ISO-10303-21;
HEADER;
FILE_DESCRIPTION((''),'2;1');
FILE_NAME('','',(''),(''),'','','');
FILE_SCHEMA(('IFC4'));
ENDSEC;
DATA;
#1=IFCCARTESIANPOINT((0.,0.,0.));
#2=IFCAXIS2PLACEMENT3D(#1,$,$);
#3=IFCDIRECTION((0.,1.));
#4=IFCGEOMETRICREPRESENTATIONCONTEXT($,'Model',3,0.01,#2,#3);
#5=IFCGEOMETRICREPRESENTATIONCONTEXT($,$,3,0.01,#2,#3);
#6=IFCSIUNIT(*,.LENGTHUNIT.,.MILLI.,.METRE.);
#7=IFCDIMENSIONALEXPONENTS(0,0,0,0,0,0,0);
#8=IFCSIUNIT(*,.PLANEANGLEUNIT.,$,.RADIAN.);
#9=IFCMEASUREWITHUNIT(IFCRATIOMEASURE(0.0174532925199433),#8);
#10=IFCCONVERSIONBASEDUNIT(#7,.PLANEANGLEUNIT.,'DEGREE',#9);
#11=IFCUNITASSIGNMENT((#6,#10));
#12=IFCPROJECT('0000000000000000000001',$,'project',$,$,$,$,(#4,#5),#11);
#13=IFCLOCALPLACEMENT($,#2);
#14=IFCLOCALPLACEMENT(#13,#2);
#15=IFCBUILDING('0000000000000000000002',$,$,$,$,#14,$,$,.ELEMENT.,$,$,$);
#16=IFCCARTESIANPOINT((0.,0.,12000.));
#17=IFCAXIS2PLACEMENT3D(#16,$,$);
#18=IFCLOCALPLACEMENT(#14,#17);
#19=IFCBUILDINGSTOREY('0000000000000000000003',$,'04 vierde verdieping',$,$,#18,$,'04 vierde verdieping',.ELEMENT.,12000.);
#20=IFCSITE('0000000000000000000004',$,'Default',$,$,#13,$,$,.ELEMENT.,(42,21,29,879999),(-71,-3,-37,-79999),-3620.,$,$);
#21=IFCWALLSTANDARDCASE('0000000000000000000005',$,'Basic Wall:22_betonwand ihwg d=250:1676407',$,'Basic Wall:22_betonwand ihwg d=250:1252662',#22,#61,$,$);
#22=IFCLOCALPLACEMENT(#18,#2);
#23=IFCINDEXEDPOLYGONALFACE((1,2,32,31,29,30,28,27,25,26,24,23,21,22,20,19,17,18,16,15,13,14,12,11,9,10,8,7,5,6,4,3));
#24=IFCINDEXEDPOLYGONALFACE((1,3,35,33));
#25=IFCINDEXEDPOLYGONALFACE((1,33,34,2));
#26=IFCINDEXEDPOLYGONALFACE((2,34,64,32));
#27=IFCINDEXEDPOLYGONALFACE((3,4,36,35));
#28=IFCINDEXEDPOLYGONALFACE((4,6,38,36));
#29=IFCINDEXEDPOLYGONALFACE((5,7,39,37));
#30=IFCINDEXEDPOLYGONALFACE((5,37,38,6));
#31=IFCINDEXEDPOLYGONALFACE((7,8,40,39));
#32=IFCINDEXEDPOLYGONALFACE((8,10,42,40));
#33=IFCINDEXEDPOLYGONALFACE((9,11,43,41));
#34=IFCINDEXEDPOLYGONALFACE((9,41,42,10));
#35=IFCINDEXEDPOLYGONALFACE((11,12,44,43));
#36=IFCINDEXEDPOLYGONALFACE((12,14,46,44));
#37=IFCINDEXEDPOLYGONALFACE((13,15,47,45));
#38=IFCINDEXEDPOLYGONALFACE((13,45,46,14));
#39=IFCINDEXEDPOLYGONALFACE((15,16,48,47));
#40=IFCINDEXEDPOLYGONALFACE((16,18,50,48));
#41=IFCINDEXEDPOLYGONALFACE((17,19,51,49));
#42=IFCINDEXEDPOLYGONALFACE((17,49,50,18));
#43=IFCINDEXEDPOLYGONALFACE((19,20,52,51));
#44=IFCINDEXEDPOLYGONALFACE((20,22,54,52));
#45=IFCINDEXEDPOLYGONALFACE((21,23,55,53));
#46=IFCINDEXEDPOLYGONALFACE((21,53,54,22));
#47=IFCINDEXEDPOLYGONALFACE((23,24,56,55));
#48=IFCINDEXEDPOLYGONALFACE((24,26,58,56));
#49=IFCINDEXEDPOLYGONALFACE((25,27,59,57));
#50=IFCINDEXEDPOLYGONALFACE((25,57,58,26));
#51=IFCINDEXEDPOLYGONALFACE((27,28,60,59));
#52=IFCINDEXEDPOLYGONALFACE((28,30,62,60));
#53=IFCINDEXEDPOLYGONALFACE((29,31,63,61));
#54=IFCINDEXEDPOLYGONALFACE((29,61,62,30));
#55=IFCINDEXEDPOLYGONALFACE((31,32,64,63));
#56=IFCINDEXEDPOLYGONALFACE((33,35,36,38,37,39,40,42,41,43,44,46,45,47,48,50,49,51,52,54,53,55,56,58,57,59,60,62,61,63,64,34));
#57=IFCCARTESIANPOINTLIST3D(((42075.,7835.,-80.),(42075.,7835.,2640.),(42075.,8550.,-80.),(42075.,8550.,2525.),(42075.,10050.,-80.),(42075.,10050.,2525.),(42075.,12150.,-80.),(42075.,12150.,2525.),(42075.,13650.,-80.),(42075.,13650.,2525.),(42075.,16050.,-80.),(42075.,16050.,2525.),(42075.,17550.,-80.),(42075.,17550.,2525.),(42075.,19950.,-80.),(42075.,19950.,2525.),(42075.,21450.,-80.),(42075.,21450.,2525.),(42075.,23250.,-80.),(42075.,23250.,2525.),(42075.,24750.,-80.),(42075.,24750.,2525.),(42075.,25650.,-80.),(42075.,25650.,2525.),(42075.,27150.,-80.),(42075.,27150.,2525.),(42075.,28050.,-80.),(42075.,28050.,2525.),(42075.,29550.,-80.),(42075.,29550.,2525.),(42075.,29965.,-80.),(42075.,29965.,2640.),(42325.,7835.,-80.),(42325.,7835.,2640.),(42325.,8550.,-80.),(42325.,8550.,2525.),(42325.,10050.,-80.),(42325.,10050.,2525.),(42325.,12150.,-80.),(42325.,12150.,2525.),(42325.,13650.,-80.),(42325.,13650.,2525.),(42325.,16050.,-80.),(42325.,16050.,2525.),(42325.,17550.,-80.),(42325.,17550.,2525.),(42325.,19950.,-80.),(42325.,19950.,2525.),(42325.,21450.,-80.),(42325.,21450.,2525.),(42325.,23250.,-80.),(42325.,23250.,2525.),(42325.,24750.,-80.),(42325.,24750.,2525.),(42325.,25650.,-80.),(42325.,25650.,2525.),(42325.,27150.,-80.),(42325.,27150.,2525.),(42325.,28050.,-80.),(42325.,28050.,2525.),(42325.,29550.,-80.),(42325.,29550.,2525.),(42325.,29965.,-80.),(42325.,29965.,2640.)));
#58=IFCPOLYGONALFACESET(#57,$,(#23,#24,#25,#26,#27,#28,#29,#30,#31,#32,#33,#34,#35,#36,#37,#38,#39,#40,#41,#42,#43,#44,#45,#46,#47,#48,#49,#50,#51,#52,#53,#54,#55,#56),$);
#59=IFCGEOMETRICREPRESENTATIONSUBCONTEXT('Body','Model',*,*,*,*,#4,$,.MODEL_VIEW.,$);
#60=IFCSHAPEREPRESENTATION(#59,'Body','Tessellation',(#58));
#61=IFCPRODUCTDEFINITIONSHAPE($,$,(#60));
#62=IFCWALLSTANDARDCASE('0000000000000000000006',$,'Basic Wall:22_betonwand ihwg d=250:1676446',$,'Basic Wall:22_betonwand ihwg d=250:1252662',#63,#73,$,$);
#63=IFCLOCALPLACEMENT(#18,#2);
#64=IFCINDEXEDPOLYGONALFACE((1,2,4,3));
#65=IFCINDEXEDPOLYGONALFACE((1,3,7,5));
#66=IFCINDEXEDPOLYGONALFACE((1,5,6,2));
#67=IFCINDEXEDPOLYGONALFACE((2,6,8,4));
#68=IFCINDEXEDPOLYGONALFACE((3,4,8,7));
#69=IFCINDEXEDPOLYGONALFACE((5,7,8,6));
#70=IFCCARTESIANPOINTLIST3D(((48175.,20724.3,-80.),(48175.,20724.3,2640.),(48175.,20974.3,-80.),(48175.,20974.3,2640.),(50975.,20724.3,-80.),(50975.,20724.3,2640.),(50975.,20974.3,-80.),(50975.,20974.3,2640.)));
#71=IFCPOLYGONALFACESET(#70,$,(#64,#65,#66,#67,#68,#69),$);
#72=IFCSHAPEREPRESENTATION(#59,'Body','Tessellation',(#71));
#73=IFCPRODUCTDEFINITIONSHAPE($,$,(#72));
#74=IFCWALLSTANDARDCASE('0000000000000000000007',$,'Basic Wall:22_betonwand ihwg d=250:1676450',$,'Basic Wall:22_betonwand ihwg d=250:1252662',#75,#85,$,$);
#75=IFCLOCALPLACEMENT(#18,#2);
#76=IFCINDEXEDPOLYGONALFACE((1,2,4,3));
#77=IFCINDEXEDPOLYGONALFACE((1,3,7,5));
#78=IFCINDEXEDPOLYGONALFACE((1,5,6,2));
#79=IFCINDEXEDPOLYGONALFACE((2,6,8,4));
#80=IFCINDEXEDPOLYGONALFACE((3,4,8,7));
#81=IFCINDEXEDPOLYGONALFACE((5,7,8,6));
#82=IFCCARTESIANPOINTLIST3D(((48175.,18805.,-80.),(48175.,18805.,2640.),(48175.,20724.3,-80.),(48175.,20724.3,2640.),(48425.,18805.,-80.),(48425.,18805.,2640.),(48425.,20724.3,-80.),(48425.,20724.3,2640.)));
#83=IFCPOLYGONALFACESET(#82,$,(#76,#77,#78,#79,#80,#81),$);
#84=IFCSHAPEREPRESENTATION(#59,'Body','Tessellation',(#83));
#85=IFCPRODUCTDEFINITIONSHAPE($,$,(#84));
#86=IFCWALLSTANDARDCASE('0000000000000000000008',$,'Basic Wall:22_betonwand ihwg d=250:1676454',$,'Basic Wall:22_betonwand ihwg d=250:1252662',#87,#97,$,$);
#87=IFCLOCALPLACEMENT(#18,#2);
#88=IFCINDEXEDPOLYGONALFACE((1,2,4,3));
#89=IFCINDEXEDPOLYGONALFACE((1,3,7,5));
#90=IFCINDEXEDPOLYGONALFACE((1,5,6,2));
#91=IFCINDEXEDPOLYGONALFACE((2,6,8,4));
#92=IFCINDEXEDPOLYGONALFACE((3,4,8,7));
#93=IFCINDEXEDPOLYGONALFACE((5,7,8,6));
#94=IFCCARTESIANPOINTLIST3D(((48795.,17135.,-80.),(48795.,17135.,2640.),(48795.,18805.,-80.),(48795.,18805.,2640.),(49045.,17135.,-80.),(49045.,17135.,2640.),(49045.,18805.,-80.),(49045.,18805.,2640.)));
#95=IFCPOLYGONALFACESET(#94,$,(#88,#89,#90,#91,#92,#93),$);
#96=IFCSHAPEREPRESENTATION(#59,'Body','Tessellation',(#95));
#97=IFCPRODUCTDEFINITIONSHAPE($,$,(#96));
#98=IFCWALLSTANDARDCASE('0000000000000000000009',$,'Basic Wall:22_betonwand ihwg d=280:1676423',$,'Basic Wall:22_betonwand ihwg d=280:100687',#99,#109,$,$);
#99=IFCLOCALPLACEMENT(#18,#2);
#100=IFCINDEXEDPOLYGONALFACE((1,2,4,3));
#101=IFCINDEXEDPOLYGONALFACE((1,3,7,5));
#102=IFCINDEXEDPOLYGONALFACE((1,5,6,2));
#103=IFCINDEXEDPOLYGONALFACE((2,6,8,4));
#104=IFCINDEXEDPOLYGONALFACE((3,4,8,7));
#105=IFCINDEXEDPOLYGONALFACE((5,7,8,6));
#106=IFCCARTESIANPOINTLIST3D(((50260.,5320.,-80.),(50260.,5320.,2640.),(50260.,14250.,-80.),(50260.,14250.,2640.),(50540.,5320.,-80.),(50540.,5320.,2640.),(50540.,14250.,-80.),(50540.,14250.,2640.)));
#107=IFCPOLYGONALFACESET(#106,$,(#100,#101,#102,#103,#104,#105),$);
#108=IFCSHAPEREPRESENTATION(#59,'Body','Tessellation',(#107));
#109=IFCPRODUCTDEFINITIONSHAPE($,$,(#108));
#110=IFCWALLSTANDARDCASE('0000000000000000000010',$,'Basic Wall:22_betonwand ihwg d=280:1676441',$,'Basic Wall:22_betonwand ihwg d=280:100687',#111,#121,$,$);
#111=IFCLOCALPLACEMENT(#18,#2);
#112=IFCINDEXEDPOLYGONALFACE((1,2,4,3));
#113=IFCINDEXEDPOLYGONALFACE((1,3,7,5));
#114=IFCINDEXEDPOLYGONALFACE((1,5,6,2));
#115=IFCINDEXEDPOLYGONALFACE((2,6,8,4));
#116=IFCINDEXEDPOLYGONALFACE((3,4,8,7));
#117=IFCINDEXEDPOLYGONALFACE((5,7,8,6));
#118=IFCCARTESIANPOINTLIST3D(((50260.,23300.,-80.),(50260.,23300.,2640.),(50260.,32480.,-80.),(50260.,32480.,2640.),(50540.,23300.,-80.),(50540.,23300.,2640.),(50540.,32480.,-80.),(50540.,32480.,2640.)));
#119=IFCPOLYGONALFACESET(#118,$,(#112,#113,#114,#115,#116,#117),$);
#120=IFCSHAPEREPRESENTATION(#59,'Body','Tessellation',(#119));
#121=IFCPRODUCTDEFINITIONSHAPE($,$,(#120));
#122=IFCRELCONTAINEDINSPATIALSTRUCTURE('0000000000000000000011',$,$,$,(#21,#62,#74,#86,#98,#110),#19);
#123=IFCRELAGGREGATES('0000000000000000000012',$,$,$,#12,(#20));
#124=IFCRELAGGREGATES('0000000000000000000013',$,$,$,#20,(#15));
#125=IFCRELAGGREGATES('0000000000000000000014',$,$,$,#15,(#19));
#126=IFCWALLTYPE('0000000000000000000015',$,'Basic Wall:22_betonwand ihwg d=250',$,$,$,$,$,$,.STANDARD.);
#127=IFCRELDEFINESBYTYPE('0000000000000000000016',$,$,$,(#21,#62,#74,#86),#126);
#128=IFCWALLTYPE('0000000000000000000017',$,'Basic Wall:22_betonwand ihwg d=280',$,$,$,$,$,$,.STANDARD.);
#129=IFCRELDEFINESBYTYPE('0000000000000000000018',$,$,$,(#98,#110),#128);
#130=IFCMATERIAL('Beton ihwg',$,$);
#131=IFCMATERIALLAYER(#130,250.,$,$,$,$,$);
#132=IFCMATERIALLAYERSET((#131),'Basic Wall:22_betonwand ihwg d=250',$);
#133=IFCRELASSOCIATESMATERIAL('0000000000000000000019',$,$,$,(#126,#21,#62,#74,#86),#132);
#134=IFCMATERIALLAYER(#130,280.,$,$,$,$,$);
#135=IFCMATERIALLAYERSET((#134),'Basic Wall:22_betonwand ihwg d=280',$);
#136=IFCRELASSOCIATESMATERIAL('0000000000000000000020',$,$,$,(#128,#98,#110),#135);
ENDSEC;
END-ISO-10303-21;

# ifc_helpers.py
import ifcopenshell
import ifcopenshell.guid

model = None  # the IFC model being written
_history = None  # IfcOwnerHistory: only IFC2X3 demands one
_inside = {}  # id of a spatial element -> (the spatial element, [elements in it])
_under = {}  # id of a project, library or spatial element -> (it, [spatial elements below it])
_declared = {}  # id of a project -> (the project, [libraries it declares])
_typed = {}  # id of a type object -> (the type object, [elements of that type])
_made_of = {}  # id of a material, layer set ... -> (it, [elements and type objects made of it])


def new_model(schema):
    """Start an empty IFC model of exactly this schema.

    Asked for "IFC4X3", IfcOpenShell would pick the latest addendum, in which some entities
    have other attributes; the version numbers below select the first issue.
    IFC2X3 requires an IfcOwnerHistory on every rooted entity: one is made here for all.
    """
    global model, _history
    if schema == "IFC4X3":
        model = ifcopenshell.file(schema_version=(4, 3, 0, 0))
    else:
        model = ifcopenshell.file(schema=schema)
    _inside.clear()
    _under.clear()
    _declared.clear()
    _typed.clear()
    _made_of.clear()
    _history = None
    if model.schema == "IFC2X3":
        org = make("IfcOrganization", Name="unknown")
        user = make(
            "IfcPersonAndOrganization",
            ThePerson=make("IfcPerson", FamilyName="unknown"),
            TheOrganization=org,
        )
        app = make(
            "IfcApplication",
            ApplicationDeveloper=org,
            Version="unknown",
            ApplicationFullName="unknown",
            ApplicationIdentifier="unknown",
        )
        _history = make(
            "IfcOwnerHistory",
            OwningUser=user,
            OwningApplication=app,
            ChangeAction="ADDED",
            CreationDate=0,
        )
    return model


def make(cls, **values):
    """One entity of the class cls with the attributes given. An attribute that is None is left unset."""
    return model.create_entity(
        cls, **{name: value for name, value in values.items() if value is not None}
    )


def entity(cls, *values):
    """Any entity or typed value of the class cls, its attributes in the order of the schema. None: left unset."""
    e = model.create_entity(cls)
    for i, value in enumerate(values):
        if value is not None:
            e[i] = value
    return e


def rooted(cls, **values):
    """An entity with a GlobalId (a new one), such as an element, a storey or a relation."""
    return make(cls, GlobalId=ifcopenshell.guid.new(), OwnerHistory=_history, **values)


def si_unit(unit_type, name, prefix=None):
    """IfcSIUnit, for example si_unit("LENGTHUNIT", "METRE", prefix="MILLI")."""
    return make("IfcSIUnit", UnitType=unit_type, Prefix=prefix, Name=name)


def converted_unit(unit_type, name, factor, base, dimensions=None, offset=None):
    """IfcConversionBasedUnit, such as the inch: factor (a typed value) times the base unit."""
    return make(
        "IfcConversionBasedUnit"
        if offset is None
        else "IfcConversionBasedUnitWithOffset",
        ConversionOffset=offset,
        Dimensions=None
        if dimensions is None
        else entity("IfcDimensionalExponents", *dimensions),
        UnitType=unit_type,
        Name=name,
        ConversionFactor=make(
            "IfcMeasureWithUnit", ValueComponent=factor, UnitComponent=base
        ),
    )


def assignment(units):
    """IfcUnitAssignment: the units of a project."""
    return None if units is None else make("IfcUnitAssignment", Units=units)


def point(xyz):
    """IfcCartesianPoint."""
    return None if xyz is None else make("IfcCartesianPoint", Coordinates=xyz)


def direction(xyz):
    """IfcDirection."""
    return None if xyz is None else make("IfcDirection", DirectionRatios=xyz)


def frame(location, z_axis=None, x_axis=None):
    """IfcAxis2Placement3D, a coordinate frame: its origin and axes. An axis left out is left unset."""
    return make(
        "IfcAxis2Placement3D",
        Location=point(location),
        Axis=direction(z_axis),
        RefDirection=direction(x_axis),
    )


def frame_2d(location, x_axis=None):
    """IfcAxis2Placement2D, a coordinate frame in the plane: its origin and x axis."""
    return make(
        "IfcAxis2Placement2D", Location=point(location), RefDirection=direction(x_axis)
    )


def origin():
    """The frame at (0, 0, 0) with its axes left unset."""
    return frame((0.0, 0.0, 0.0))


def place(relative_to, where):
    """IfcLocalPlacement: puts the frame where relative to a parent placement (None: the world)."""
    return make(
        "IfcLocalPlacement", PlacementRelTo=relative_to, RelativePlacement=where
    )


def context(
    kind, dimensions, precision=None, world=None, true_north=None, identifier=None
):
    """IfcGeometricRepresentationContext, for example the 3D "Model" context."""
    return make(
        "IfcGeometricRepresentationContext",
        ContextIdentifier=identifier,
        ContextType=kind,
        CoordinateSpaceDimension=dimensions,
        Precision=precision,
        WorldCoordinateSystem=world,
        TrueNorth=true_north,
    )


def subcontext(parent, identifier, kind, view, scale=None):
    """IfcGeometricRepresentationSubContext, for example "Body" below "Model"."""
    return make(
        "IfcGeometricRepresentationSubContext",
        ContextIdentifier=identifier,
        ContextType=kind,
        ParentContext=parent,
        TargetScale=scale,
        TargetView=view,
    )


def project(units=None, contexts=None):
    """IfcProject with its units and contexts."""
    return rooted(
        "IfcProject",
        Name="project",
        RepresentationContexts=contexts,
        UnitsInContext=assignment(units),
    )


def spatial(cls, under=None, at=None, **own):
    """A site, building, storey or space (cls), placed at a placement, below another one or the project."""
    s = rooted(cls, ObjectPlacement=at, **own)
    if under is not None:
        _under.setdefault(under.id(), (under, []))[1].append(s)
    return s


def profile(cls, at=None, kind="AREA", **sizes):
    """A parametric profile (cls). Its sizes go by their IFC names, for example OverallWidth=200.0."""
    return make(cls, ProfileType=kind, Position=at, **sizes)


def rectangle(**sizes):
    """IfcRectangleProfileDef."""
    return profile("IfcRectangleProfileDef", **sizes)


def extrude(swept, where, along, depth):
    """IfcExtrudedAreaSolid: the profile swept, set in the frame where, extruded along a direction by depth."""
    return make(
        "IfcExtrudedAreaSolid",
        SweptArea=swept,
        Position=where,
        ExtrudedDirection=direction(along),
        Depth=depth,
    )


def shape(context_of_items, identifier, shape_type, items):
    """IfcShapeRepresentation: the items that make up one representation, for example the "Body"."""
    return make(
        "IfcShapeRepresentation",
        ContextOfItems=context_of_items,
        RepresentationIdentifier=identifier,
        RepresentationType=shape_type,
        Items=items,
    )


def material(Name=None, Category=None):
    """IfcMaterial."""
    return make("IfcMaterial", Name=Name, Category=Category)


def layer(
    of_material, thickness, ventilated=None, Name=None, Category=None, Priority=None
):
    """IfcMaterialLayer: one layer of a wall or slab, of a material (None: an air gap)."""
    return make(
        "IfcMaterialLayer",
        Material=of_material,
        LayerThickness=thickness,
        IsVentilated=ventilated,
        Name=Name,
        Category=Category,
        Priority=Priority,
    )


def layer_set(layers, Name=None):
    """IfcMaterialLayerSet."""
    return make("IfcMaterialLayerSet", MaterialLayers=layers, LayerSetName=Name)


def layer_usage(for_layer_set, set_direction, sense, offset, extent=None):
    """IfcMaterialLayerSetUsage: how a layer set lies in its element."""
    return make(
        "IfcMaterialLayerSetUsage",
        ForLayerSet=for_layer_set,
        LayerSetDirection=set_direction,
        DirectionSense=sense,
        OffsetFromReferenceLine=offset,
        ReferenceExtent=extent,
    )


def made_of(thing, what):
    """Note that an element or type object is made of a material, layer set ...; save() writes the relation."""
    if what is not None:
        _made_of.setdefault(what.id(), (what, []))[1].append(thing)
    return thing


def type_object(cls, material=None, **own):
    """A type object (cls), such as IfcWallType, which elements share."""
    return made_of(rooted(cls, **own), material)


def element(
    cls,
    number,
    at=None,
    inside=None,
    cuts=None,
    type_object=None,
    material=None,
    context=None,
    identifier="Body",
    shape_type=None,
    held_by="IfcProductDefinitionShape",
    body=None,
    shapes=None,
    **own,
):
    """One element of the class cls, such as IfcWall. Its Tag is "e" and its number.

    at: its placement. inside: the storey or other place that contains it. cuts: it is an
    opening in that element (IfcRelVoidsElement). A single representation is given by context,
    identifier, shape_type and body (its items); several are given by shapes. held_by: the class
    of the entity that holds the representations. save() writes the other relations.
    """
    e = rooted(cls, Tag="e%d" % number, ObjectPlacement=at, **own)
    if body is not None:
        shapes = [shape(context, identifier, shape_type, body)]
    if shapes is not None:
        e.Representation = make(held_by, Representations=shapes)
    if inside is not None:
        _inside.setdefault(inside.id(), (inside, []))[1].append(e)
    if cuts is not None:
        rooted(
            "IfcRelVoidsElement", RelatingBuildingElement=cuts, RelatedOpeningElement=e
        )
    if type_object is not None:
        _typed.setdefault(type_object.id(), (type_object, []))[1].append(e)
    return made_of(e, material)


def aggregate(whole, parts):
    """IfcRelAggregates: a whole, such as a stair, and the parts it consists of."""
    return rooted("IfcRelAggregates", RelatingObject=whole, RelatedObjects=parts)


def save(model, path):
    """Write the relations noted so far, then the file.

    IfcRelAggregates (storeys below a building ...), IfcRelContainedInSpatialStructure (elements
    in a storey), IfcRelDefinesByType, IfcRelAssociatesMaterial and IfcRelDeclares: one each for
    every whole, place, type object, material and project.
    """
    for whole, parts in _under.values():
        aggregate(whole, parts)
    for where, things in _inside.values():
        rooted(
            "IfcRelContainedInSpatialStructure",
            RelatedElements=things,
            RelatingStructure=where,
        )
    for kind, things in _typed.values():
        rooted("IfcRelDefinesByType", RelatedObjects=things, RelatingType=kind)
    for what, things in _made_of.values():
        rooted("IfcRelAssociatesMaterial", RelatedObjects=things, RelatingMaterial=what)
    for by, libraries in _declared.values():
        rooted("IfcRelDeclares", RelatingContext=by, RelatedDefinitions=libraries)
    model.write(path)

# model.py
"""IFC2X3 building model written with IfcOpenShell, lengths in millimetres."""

from ifc_helpers import new_model, entity, si_unit, converted_unit, direction, frame, frame_2d, origin, place, context, subcontext, project, spatial, rectangle, extrude, material, layer, layer_set, layer_usage, type_object, element, save


model = new_model("IFC2X3")

# Units and contexts
model_context = context("Model", 3, precision=0.01, world=origin(), true_north=direction((0.0, 1.0)))
context_of_model = context(None, 3, precision=0.01, world=origin(), true_north=direction((0.0, 1.0)))
body_context = subcontext(model_context, "Body", "Model", "MODEL_VIEW")
ifc_project = project(units=[si_unit("LENGTHUNIT", "METRE", prefix="MILLI"), converted_unit("PLANEANGLEUNIT", "DEGREE", entity("IfcRatioMeasure", 0.0174532925199433), si_unit("PLANEANGLEUNIT", "RADIAN"), dimensions=[0, 0, 0, 0, 0, 0, 0])], contexts=[model_context, context_of_model])

# Site, building, storey
site_placement = place(None, origin())
site = spatial("IfcSite", under=ifc_project, at=site_placement, Name="Default", CompositionType="ELEMENT", RefLatitude=(42, 21, 29, 879999), RefLongitude=(-71, -3, -37, -79999), RefElevation=-3620.0)
building_placement = place(site_placement, origin())
building = spatial("IfcBuilding", under=site, at=building_placement, CompositionType="ELEMENT")
storey_placement = place(building_placement, frame((0.0, 0.0, 12000.0)))
storey = spatial("IfcBuildingStorey", under=building, at=storey_placement, Name="04 vierde verdieping", LongName="04 vierde verdieping", CompositionType="ELEMENT", Elevation=12000.0)

# Shared definitions
ifc_material_1 = material(Name="Beton ihwg")

# Wall, openings
ifc_layer_1 = layer(ifc_material_1, 250.0)
ifc_layer_set_1 = layer_set([ifc_layer_1], Name="Basic Wall:22_betonwand ihwg d=250")
ifc_layer_usage_1 = layer_usage(ifc_layer_set_1, "AXIS2", "POSITIVE", -125.0)
wall_type_1 = type_object("IfcWallType", Name="Basic Wall:22_betonwand ihwg d=250", PredefinedType="STANDARD", material=ifc_layer_set_1)
wall_1_placement = place(storey_placement, frame((42200.0, 29965.0, -80.0), z_axis=(0.0, 0.0, 1.0), x_axis=(0.0, -1.0, 0.0)))
wall_1 = element("IfcWallStandardCase", 1, at=wall_1_placement, inside=storey, type_object=wall_type_1, material=ifc_layer_usage_1, Name="Basic Wall:22_betonwand ihwg d=250:1676407", ObjectType="Basic Wall:22_betonwand ihwg d=250:1252662", context=body_context, shape_type="SweptSolid", body=[
    extrude(rectangle(XDim=22130.0, YDim=250.0, at=frame_2d((11065.0, 0.0), x_axis=(-1.0, 0.0))), origin(), (0.0, 0.0, 1.0), 2720.0),
])
opening_1_placement = place(wall_1_placement, frame((29965.0, -42200.0, 80.0), z_axis=(0.0, 0.0, 1.0), x_axis=(0.0, 1.0, 0.0)))
element("IfcOpeningElement", 2, at=opening_1_placement, cuts=wall_1, ObjectType="Opening", context=body_context, shape_type="SweptSolid", body=[
    extrude(rectangle(XDim=2605.0, YDim=1500.0, at=frame_2d((0.0, 0.0), x_axis=(1.0, 0.0))), frame((40801.0, 28800.0, 1222.5), z_axis=(1.0, 0.0, 0.0), x_axis=(0.0, 0.0, -1.0)), (0.0, 0.0, 1.0), 3048.0),
])
opening_2_placement = place(wall_1_placement, frame((29965.0, -42200.0, 80.0), z_axis=(0.0, 0.0, 1.0), x_axis=(0.0, 1.0, 0.0)))
element("IfcOpeningElement", 3, at=opening_2_placement, cuts=wall_1, ObjectType="Opening", context=body_context, shape_type="SweptSolid", body=[
    extrude(rectangle(XDim=2605.0, YDim=1500.0, at=frame_2d((0.0, 0.0), x_axis=(1.0, 0.0))), frame((40801.0, 26400.0, 1222.5), z_axis=(1.0, 0.0, 0.0), x_axis=(0.0, 0.0, -1.0)), (0.0, 0.0, 1.0), 3048.0),
])
opening_3_placement = place(wall_1_placement, frame((29965.0, -42200.0, 80.0), z_axis=(0.0, 0.0, 1.0), x_axis=(0.0, 1.0, 0.0)))
element("IfcOpeningElement", 4, at=opening_3_placement, cuts=wall_1, ObjectType="Opening", context=body_context, shape_type="SweptSolid", body=[
    extrude(rectangle(XDim=2605.0, YDim=1500.0, at=frame_2d((0.0, 0.0), x_axis=(1.0, 0.0))), frame((40801.0, 24000.0, 1222.5), z_axis=(1.0, 0.0, 0.0), x_axis=(0.0, 0.0, -1.0)), (0.0, 0.0, 1.0), 3048.0),
])
opening_4_placement = place(wall_1_placement, frame((29965.0, -42200.0, 80.0), z_axis=(0.0, 0.0, 1.0), x_axis=(0.0, 1.0, 0.0)))
element("IfcOpeningElement", 5, at=opening_4_placement, cuts=wall_1, ObjectType="Opening", context=body_context, shape_type="SweptSolid", body=[
    extrude(rectangle(XDim=2605.0, YDim=1500.0, at=frame_2d((0.0, 0.0), x_axis=(1.0, 0.0))), frame((40801.0, 16800.0, 1222.5), z_axis=(1.0, 0.0, 0.0), x_axis=(0.0, 0.0, -1.0)), (0.0, 0.0, 1.0), 3048.0),
])
opening_5_placement = place(wall_1_placement, frame((29965.0, -42200.0, -2920.0), z_axis=(0.0, 0.0, 1.0), x_axis=(0.0, 1.0, 0.0)))
element("IfcOpeningElement", 6, at=opening_5_placement, cuts=wall_1, ObjectType="Opening", context=body_context, shape_type="SweptSolid", body=[
    extrude(rectangle(XDim=2605.0, YDim=1500.0, at=frame_2d((0.0, 0.0), x_axis=(1.0, 0.0))), frame((40801.0, 9300.0, 4222.5), z_axis=(1.0, 0.0, 0.0), x_axis=(0.0, 0.0, -1.0)), (0.0, 0.0, 1.0), 3048.0),
])
opening_6_placement = place(wall_1_placement, frame((29965.0, -42200.0, 80.0), z_axis=(0.0, 0.0, 1.0), x_axis=(0.0, 1.0, 0.0)))
element("IfcOpeningElement", 7, at=opening_6_placement, cuts=wall_1, ObjectType="Opening", context=body_context, shape_type="SweptSolid", body=[
    extrude(rectangle(XDim=2605.0, YDim=1500.0, at=frame_2d((0.0, 0.0), x_axis=(0.0, 1.0))), frame((40551.0, 12900.0, 1222.5), z_axis=(1.0, 0.0, 0.0), x_axis=(0.0, -1.0, 0.0)), (0.0, 0.0, 1.0), 3048.0),
])
opening_7_placement = place(wall_1_placement, frame((29965.0, -42200.0, 80.0), z_axis=(0.0, 0.0, 1.0), x_axis=(0.0, 1.0, 0.0)))
element("IfcOpeningElement", 8, at=opening_7_placement, cuts=wall_1, ObjectType="Opening", context=body_context, shape_type="SweptSolid", body=[
    extrude(rectangle(XDim=2605.0, YDim=1500.0, at=frame_2d((0.0, 0.0), x_axis=(1.0, 0.0))), frame((40801.0, 20700.0, 1222.5), z_axis=(1.0, 0.0, 0.0), x_axis=(0.0, 0.0, -1.0)), (0.0, 0.0, 1.0), 3048.0),
])

# Walls
ifc_layer_usage_2 = layer_usage(ifc_layer_set_1, "AXIS2", "POSITIVE", -125.0)
wall_2_placement = place(storey_placement, frame((50975.0, 20849.3, -80.0), z_axis=(0.0, 0.0, 1.0), x_axis=(-1.0, 0.0, 0.0)))
element("IfcWallStandardCase", 9, at=wall_2_placement, inside=storey, type_object=wall_type_1, material=ifc_layer_usage_2, Name="Basic Wall:22_betonwand ihwg d=250:1676446", ObjectType="Basic Wall:22_betonwand ihwg d=250:1252662", context=body_context, shape_type="SweptSolid", body=[
    extrude(rectangle(XDim=2800.0, YDim=250.0, at=frame_2d((1400.0, 0.0), x_axis=(-1.0, 0.0))), origin(), (0.0, 0.0, 1.0), 2720.0),
])
ifc_layer_usage_3 = layer_usage(ifc_layer_set_1, "AXIS2", "POSITIVE", -125.0)
wall_3_placement = place(storey_placement, frame((48300.0, 20724.3, -80.0), z_axis=(0.0, 0.0, 1.0), x_axis=(0.0, -1.0, 0.0)))
element("IfcWallStandardCase", 10, at=wall_3_placement, inside=storey, type_object=wall_type_1, material=ifc_layer_usage_3, Name="Basic Wall:22_betonwand ihwg d=250:1676450", ObjectType="Basic Wall:22_betonwand ihwg d=250:1252662", context=body_context, shape_type="SweptSolid", body=[
    extrude(rectangle(XDim=1919.3, YDim=250.0, at=frame_2d((959.6, 0.0), x_axis=(-1.0, 0.0))), origin(), (0.0, 0.0, 1.0), 2720.0),
])
ifc_layer_usage_4 = layer_usage(ifc_layer_set_1, "AXIS2", "POSITIVE", -125.0)
wall_4_placement = place(storey_placement, frame((48920.0, 18805.0, -80.0), z_axis=(0.0, 0.0, 1.0), x_axis=(0.0, -1.0, 0.0)))
element("IfcWallStandardCase", 11, at=wall_4_placement, inside=storey, type_object=wall_type_1, material=ifc_layer_usage_4, Name="Basic Wall:22_betonwand ihwg d=250:1676454", ObjectType="Basic Wall:22_betonwand ihwg d=250:1252662", context=body_context, shape_type="SweptSolid", body=[
    extrude(rectangle(XDim=1670.0, YDim=250.0, at=frame_2d((835.0, 0.0), x_axis=(-1.0, 0.0))), origin(), (0.0, 0.0, 1.0), 2720.0),
])
ifc_layer_2 = layer(ifc_material_1, 280.0)
ifc_layer_set_2 = layer_set([ifc_layer_2], Name="Basic Wall:22_betonwand ihwg d=280")
ifc_layer_usage_5 = layer_usage(ifc_layer_set_2, "AXIS2", "NEGATIVE", 140.0)
wall_type_2 = type_object("IfcWallType", Name="Basic Wall:22_betonwand ihwg d=280", PredefinedType="STANDARD", material=ifc_layer_set_2)
wall_5_placement = place(storey_placement, frame((50400.0, 14250.0, -80.0), z_axis=(0.0, 0.0, 1.0), x_axis=(0.0, -1.0, 0.0)))
element("IfcWallStandardCase", 12, at=wall_5_placement, inside=storey, type_object=wall_type_2, material=ifc_layer_usage_5, Name="Basic Wall:22_betonwand ihwg d=280:1676423", ObjectType="Basic Wall:22_betonwand ihwg d=280:100687", context=body_context, shape_type="SweptSolid", body=[
    extrude(rectangle(XDim=8930.0, YDim=280.0, at=frame_2d((4465.0, 0.0), x_axis=(-1.0, 0.0))), origin(), (0.0, 0.0, 1.0), 2720.0),
])
ifc_layer_usage_6 = layer_usage(ifc_layer_set_2, "AXIS2", "POSITIVE", -140.0)
wall_6_placement = place(storey_placement, frame((50400.0, 23300.0, -80.0), z_axis=(0.0, 0.0, 1.0), x_axis=(0.0, 1.0, 0.0)))
element("IfcWallStandardCase", 13, at=wall_6_placement, inside=storey, type_object=wall_type_2, material=ifc_layer_usage_6, Name="Basic Wall:22_betonwand ihwg d=280:1676441", ObjectType="Basic Wall:22_betonwand ihwg d=280:100687", context=body_context, shape_type="SweptSolid", body=[
    extrude(rectangle(XDim=9180.0, YDim=280.0, at=frame_2d((4590.0, 0.0), x_axis=(-1.0, 0.0))), origin(), (0.0, 0.0, 1.0), 2720.0),
])

save(model, "model.ifc")
